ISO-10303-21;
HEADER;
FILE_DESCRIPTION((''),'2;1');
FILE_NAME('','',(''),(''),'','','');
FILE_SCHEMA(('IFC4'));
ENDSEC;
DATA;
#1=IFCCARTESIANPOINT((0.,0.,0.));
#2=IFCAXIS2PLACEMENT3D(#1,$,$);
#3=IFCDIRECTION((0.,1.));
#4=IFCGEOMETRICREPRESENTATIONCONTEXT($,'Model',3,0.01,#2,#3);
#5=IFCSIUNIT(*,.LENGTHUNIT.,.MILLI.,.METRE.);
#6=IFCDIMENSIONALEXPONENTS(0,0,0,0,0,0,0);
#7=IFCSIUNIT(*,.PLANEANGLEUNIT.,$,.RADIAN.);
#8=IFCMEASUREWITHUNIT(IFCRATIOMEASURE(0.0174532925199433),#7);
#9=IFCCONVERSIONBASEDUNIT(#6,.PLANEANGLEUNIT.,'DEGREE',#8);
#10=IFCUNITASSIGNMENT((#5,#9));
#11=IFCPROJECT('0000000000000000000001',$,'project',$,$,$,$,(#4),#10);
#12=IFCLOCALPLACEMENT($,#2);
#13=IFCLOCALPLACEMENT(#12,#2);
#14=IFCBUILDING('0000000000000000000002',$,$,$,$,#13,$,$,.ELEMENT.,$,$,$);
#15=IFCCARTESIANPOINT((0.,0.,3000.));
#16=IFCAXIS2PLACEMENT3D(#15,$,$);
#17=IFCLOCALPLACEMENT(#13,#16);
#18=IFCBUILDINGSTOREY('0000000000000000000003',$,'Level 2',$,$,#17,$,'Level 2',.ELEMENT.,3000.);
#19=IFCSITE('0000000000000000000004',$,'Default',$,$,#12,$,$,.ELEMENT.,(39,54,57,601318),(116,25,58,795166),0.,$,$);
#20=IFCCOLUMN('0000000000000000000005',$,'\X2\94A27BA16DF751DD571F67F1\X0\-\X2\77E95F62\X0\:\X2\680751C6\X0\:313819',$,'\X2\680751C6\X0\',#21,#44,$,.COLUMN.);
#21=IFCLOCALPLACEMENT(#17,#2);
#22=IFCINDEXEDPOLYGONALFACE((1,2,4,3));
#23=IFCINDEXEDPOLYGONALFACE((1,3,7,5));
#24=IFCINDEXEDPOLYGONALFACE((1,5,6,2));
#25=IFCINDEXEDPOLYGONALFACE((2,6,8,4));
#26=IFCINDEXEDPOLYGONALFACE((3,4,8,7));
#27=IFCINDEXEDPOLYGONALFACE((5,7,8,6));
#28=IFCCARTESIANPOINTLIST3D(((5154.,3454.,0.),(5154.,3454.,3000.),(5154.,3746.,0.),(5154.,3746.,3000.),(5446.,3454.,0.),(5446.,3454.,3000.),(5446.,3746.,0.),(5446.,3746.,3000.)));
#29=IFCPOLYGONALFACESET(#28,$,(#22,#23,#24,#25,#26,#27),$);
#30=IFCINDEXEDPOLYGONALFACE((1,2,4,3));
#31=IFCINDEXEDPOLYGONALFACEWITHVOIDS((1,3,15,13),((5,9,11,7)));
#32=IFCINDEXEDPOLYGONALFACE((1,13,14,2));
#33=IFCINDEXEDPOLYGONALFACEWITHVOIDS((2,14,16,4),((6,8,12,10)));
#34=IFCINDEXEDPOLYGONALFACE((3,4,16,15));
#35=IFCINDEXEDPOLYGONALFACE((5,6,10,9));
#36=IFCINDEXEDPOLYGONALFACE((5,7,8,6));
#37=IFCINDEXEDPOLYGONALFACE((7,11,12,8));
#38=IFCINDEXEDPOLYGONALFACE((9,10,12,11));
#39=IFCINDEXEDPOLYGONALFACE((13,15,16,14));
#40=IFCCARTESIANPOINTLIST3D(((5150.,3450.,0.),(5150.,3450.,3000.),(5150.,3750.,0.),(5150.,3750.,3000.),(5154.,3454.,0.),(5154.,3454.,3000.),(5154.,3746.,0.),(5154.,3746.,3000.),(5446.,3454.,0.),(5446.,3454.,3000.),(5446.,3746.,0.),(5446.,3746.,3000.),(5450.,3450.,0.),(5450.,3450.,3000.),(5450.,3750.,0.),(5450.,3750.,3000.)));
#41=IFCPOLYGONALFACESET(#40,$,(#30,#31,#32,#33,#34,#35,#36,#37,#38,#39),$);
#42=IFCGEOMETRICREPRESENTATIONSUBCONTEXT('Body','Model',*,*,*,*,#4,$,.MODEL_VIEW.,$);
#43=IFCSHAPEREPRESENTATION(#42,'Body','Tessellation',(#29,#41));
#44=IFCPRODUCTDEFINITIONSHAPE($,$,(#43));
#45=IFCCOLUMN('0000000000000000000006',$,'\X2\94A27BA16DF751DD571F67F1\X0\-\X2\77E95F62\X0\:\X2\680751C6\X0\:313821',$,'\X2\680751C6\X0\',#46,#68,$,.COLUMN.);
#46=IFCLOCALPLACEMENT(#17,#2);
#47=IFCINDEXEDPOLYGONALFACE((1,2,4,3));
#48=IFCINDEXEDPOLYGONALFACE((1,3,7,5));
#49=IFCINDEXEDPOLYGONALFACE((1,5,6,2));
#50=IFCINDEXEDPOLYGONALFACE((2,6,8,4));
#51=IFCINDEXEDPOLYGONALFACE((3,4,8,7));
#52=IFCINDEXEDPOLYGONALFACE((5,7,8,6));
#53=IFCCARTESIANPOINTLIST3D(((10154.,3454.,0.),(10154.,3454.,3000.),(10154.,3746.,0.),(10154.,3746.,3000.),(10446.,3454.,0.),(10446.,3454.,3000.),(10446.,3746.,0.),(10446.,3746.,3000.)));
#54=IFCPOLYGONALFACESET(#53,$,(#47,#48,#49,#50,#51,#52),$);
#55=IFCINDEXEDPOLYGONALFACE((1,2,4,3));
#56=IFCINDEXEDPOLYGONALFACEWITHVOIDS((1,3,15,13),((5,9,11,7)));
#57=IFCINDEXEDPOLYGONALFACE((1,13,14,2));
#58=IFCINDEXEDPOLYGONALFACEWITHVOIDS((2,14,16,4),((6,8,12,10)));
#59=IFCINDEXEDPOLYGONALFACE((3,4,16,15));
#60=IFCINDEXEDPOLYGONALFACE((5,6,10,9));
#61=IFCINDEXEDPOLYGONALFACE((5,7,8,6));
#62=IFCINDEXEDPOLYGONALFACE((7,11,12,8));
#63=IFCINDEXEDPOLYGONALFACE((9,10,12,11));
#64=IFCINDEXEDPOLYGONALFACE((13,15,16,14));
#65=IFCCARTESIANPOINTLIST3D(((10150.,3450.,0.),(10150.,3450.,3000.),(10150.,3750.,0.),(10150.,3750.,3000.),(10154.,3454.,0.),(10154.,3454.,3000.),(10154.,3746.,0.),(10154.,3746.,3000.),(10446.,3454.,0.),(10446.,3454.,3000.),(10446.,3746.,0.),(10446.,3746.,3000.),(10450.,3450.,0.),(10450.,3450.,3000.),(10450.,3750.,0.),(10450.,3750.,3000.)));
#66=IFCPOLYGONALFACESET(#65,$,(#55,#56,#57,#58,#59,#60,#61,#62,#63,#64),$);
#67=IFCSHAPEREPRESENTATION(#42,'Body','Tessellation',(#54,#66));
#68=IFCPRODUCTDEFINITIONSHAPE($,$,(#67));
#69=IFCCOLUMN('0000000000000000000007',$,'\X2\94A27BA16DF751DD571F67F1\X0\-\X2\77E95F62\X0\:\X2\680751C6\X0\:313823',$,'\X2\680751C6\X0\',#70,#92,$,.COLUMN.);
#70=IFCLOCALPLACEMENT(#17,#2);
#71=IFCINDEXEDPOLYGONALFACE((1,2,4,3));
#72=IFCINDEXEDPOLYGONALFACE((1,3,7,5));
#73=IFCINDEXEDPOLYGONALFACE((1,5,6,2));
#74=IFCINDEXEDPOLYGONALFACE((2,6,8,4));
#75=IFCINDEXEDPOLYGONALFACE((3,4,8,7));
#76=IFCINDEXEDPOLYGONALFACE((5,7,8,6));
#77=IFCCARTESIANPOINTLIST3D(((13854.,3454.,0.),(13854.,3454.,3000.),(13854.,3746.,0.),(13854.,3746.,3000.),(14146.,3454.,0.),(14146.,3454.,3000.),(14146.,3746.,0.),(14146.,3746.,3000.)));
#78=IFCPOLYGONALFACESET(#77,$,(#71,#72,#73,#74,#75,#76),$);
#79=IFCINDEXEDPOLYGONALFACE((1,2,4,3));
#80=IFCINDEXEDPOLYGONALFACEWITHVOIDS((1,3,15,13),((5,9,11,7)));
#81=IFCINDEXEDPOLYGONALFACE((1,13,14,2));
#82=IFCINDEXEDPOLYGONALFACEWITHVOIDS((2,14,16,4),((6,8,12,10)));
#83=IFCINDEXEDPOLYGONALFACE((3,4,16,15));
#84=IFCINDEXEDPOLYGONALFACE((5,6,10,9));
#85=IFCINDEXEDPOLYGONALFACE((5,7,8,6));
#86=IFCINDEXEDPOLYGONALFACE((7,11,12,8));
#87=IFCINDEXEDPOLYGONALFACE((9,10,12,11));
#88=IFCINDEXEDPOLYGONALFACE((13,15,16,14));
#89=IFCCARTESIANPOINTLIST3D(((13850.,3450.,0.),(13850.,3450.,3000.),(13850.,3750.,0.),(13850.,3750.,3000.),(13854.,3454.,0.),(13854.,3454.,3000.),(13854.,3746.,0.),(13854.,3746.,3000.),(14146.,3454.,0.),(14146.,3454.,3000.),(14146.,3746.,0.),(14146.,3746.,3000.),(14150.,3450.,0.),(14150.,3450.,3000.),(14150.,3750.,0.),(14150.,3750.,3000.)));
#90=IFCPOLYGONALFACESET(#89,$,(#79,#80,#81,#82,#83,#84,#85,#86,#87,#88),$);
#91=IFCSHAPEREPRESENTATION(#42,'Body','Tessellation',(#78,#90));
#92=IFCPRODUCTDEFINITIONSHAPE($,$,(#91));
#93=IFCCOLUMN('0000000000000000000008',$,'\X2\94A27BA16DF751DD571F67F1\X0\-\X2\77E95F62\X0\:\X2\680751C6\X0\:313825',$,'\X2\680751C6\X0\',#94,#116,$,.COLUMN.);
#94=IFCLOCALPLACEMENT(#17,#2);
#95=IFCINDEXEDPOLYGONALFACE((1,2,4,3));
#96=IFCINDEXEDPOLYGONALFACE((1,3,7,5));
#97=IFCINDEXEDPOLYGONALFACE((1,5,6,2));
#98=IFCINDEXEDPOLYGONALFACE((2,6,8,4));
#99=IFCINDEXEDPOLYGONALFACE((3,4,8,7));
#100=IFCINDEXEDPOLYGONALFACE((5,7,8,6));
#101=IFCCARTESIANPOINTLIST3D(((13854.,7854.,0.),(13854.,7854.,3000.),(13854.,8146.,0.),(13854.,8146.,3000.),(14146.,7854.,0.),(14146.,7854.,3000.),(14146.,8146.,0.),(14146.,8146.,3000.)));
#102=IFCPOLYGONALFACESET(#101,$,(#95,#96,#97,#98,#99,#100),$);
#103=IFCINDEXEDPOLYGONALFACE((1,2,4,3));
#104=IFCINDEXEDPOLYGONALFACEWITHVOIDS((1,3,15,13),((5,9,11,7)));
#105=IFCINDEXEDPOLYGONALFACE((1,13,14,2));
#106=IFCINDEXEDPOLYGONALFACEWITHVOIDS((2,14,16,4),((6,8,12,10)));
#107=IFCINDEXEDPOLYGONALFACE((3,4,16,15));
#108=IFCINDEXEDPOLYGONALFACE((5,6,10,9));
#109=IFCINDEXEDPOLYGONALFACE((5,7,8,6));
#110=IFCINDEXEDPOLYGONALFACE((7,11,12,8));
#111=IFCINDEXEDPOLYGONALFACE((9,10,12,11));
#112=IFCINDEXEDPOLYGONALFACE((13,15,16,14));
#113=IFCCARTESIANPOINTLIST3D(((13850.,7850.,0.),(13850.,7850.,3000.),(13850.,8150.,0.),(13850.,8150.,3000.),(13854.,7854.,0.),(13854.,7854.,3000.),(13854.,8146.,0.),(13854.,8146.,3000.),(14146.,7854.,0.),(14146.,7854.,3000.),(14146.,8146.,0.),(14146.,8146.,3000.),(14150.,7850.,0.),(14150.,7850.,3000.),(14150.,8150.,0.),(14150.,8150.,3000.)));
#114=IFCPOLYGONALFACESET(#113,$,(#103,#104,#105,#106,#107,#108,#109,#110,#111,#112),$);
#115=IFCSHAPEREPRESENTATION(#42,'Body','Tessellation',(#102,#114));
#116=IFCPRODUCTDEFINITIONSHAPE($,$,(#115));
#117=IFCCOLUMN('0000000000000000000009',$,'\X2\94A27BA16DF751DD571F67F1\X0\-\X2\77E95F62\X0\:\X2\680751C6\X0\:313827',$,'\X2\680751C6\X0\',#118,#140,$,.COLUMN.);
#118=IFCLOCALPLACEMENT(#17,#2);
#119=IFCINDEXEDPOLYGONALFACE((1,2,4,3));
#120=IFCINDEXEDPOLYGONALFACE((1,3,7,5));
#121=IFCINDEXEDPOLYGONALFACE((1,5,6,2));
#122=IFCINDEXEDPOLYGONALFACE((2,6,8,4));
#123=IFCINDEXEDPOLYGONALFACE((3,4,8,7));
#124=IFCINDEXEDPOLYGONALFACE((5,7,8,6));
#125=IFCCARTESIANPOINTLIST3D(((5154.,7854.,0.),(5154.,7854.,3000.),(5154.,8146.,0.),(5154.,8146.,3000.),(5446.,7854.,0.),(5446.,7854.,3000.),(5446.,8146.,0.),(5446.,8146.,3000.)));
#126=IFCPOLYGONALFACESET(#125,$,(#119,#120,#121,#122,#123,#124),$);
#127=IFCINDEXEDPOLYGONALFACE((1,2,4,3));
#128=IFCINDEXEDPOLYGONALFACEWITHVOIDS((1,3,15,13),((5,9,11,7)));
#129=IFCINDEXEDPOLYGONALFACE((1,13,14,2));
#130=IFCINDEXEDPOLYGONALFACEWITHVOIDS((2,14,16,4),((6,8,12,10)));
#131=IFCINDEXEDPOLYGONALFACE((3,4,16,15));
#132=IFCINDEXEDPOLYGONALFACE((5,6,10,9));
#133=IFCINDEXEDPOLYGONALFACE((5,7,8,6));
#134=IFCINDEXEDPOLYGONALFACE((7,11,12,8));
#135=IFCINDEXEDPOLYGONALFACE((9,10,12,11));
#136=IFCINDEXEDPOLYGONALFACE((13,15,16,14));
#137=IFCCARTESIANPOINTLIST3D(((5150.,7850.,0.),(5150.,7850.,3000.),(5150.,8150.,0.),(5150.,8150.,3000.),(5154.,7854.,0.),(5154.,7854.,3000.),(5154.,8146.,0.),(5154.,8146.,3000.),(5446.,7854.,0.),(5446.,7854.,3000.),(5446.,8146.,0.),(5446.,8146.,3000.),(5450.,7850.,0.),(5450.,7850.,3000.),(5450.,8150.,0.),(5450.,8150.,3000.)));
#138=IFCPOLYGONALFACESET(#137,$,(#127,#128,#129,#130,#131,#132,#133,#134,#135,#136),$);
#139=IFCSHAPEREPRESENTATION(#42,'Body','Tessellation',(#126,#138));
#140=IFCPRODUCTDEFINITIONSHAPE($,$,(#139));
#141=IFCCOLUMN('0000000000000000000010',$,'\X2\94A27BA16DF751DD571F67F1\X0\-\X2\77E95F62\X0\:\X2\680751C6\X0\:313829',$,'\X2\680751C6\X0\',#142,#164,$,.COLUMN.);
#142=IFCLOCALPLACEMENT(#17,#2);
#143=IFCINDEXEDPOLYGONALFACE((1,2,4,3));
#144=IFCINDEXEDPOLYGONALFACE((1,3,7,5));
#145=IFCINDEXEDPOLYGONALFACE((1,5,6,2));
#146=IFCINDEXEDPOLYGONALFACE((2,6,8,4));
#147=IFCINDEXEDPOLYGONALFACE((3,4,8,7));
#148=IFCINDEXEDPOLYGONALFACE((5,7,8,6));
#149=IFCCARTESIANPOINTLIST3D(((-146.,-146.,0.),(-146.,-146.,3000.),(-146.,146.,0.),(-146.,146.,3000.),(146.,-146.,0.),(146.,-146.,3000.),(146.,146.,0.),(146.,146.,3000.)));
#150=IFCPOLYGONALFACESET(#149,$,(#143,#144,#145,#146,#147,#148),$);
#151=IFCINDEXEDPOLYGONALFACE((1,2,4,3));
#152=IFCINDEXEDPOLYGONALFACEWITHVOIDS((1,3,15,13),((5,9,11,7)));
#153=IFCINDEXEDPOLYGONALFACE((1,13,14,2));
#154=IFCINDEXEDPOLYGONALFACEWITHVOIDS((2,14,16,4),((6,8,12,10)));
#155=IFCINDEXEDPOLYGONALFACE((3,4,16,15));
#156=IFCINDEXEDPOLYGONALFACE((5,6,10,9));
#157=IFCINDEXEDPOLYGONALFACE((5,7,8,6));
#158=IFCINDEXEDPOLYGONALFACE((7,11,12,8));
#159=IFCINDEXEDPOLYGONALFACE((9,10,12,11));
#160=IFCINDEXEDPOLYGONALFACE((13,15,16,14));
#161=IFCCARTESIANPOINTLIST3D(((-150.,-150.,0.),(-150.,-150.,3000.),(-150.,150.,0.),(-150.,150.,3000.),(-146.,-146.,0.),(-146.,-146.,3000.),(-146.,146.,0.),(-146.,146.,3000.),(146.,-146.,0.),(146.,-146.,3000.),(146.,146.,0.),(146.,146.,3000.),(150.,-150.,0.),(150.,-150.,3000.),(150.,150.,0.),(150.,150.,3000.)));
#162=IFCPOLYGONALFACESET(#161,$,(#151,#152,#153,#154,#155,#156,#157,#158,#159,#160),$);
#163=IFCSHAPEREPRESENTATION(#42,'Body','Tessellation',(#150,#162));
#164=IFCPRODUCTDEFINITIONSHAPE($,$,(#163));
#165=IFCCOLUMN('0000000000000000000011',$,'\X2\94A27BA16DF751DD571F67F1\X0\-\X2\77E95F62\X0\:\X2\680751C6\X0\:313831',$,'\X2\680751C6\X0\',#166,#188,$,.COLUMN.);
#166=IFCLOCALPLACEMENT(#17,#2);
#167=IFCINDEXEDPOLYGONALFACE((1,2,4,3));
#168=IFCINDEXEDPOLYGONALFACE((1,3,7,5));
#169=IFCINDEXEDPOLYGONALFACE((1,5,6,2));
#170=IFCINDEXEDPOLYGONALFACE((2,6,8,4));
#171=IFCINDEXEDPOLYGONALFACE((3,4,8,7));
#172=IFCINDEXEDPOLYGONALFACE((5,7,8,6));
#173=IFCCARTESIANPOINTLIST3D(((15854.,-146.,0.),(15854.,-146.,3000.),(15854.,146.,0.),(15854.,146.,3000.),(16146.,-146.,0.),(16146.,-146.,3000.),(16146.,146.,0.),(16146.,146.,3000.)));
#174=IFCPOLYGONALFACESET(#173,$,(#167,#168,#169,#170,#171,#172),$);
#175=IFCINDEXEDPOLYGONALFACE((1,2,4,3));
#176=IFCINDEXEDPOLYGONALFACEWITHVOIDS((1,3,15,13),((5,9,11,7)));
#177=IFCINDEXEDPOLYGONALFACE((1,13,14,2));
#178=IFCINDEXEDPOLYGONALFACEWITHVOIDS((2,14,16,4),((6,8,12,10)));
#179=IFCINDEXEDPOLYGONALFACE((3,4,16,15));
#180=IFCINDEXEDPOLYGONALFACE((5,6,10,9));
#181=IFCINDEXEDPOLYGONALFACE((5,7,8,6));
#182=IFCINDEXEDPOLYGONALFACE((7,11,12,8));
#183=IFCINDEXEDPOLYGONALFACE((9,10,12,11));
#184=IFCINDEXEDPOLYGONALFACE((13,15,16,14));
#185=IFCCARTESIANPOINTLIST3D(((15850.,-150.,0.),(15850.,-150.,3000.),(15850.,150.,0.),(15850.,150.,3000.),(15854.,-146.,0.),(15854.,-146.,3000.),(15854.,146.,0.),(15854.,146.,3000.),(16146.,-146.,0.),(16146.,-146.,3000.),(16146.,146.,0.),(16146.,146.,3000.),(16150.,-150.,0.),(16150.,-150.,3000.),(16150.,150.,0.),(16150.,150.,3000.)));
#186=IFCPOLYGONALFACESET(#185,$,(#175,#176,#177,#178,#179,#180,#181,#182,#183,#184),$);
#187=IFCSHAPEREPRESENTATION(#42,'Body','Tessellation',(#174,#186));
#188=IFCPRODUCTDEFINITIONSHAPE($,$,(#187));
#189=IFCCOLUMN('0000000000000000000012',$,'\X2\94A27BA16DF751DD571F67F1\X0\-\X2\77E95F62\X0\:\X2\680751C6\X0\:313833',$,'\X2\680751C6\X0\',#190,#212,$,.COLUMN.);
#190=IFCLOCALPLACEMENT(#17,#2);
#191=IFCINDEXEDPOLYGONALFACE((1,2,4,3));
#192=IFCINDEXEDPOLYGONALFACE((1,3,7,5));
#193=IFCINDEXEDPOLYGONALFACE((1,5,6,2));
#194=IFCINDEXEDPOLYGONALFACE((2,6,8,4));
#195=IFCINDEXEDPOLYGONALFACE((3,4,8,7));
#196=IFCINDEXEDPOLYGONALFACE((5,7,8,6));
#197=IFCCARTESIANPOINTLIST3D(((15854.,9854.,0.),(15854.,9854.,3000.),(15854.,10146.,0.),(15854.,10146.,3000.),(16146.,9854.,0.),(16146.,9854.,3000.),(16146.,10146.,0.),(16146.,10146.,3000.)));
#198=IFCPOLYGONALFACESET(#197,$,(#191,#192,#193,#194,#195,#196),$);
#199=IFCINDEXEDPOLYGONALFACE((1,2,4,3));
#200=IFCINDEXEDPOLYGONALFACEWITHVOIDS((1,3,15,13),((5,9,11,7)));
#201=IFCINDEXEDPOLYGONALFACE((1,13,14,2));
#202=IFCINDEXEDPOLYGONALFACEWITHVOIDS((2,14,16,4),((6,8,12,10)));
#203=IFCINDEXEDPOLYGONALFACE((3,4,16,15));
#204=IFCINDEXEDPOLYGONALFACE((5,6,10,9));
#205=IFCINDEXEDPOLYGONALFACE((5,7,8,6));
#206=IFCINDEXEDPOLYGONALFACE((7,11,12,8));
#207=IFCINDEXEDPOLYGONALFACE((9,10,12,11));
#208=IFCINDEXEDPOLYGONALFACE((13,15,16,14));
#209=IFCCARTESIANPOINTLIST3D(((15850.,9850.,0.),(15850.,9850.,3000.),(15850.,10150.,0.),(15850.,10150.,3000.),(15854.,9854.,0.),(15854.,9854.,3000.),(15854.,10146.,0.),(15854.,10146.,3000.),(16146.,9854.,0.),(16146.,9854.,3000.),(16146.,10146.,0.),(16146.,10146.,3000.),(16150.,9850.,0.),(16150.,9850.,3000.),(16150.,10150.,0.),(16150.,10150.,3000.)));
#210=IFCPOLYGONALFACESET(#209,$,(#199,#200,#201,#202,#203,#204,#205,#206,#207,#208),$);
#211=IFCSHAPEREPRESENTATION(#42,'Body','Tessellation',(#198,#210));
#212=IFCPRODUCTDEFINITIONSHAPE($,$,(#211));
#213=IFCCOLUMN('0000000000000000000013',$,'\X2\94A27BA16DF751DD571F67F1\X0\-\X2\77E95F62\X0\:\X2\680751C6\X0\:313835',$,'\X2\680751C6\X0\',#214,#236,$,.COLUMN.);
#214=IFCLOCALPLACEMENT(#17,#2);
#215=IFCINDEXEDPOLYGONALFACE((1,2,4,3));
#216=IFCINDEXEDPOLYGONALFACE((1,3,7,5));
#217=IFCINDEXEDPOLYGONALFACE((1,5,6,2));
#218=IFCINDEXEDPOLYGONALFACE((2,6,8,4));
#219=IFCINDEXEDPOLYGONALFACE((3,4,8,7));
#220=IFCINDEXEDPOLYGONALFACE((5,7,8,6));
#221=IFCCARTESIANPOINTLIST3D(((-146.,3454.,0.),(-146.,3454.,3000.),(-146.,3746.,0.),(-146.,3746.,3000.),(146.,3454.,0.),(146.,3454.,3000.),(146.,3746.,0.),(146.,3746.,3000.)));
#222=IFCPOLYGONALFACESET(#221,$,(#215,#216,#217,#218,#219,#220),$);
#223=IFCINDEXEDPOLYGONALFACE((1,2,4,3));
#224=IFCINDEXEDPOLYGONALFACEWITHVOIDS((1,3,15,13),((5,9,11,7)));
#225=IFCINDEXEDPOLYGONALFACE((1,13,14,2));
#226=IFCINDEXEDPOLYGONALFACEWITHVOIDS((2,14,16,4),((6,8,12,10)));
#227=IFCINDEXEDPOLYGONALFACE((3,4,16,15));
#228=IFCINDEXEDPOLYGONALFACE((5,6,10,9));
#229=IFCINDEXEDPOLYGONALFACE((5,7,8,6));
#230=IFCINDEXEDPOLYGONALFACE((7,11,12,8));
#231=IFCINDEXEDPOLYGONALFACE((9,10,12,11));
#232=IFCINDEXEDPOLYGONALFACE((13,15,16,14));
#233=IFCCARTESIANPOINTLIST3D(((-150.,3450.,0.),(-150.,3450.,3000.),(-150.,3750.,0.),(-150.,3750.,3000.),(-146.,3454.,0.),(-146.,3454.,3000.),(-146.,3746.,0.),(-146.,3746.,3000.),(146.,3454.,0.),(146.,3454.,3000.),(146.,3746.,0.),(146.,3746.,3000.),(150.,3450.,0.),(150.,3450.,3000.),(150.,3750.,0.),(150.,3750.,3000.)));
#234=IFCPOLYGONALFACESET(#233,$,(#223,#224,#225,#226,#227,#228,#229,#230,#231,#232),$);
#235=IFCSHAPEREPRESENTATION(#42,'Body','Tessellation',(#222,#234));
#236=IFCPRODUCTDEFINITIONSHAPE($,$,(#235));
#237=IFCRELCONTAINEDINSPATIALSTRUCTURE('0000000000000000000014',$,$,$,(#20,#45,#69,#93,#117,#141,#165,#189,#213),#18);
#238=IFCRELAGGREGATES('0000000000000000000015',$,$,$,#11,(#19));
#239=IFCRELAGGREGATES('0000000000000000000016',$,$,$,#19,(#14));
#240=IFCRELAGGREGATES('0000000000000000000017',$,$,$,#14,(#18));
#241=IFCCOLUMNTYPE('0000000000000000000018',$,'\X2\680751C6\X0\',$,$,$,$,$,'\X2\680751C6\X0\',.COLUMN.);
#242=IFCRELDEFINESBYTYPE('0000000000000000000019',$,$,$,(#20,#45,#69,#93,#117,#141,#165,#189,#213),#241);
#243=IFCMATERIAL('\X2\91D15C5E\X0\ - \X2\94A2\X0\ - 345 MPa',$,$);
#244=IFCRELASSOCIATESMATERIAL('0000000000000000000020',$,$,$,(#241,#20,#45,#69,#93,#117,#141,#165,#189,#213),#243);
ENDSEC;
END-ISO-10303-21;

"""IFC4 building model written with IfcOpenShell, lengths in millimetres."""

from ifc_helpers import new_model, entity, si_unit, converted_unit, direction, frame, origin, origin_2d_with_axis, place, context, subcontext, project, spatial, polyline, rectangle, outline, extrude, source, transform, mapped, material, type_object, type_shapes, element, save


model = new_model("IFC4")

# Units and contexts
model_context_1 = context("Model", 3, precision=0.01, world=origin(), true_north=direction((0.0, 1.0)))
body_context_1 = subcontext(model_context_1, "Body", "Model", "MODEL_VIEW")
ifc_project = project(units=[si_unit("LENGTHUNIT", "METRE", prefix="MILLI"), converted_unit("PLANEANGLEUNIT", "DEGREE", entity("IfcRatioMeasure", 0.0174532925199433), si_unit("PLANEANGLEUNIT", "RADIAN"), dimensions=[0, 0, 0, 0, 0, 0, 0])], contexts=[model_context_1])

# Site, building, storey
site_placement = place(None, origin())
site = spatial("IfcSite", under=ifc_project, at=site_placement, Name="Default", CompositionType="ELEMENT", RefLatitude=(39, 54, 57, 601318), RefLongitude=(116, 25, 58, 795166), RefElevation=0.0)
building_placement = place(site_placement, origin())
building = spatial("IfcBuilding", under=site, at=building_placement, CompositionType="ELEMENT")
storey_placement = place(building_placement, frame((0.0, 0.0, 3000.0)))
storey = spatial("IfcBuildingStorey", under=building, at=storey_placement, Name="Level 2", LongName="Level 2", CompositionType="ELEMENT", Elevation=3000.0)

# Columns
ifc_material_1 = material(Name="金属 - 钢 - 345 MPa")
column_type = type_object("IfcColumnType", Name="标准", ElementType="标准", PredefinedType="COLUMN", material=ifc_material_1)
shared_shape = source(origin(), body_context_1, "Body", "SweptSolid", [
    extrude(rectangle(XDim=292.0, YDim=292.0, at=origin_2d_with_axis()), frame((150.0, 150.0, 0.0), z_axis=(0.0, 0.0, 1.0), x_axis=(-1.0, 0.0, 0.0)), (0.0, 0.0, 1.0), 3000.0),
    extrude(outline(polyline([(-150.0, -150.0), (150.0, -150.0), (150.0, 150.0), (-150.0, 150.0), (-150.0, -150.0)]), holes=[polyline([(-146.0, -146.0), (-146.0, 146.0), (146.0, 146.0), (146.0, -146.0), (-146.0, -146.0)])]), frame((150.0, 150.0, 0.0), z_axis=(0.0, 0.0, 1.0), x_axis=(-1.0, 0.0, 0.0)), (0.0, 0.0, 1.0), 3000.0),
])
type_shapes(column_type, [shared_shape])
for number, where, name in (
    (1, (5150.0, 3450.0, 0.0), "钢管混凝土柱-矩形:标准:313819"),
    (2, (10150.0, 3450.0, 0.0), "钢管混凝土柱-矩形:标准:313821"),
    (3, (13850.0, 3450.0, 0.0), "钢管混凝土柱-矩形:标准:313823"),
    (4, (13850.0, 7850.0, 0.0), "钢管混凝土柱-矩形:标准:313825"),
    (5, (5150.0, 7850.0, 0.0), "钢管混凝土柱-矩形:标准:313827"),
    (6, (-150.0, -150.0, 0.0), "钢管混凝土柱-矩形:标准:313829"),
    (7, (15850.0, -150.0, 0.0), "钢管混凝土柱-矩形:标准:313831"),
    (8, (15850.0, 9850.0, 0.0), "钢管混凝土柱-矩形:标准:313833"),
    (9, (-150.0, 3450.0, 0.0), "钢管混凝土柱-矩形:标准:313835"),
):
    element("IfcColumn", number, at=place(storey_placement, frame(where)), inside=storey, type_object=column_type, material=ifc_material_1, Name=name, ObjectType="标准", PredefinedType="COLUMN", context=body_context_1, shape_type="MappedRepresentation", body=[
        mapped(shared_shape, transform((0.0, 0.0, 0.0), scale=1.0)),
    ])

save(model, "model.ifc")
